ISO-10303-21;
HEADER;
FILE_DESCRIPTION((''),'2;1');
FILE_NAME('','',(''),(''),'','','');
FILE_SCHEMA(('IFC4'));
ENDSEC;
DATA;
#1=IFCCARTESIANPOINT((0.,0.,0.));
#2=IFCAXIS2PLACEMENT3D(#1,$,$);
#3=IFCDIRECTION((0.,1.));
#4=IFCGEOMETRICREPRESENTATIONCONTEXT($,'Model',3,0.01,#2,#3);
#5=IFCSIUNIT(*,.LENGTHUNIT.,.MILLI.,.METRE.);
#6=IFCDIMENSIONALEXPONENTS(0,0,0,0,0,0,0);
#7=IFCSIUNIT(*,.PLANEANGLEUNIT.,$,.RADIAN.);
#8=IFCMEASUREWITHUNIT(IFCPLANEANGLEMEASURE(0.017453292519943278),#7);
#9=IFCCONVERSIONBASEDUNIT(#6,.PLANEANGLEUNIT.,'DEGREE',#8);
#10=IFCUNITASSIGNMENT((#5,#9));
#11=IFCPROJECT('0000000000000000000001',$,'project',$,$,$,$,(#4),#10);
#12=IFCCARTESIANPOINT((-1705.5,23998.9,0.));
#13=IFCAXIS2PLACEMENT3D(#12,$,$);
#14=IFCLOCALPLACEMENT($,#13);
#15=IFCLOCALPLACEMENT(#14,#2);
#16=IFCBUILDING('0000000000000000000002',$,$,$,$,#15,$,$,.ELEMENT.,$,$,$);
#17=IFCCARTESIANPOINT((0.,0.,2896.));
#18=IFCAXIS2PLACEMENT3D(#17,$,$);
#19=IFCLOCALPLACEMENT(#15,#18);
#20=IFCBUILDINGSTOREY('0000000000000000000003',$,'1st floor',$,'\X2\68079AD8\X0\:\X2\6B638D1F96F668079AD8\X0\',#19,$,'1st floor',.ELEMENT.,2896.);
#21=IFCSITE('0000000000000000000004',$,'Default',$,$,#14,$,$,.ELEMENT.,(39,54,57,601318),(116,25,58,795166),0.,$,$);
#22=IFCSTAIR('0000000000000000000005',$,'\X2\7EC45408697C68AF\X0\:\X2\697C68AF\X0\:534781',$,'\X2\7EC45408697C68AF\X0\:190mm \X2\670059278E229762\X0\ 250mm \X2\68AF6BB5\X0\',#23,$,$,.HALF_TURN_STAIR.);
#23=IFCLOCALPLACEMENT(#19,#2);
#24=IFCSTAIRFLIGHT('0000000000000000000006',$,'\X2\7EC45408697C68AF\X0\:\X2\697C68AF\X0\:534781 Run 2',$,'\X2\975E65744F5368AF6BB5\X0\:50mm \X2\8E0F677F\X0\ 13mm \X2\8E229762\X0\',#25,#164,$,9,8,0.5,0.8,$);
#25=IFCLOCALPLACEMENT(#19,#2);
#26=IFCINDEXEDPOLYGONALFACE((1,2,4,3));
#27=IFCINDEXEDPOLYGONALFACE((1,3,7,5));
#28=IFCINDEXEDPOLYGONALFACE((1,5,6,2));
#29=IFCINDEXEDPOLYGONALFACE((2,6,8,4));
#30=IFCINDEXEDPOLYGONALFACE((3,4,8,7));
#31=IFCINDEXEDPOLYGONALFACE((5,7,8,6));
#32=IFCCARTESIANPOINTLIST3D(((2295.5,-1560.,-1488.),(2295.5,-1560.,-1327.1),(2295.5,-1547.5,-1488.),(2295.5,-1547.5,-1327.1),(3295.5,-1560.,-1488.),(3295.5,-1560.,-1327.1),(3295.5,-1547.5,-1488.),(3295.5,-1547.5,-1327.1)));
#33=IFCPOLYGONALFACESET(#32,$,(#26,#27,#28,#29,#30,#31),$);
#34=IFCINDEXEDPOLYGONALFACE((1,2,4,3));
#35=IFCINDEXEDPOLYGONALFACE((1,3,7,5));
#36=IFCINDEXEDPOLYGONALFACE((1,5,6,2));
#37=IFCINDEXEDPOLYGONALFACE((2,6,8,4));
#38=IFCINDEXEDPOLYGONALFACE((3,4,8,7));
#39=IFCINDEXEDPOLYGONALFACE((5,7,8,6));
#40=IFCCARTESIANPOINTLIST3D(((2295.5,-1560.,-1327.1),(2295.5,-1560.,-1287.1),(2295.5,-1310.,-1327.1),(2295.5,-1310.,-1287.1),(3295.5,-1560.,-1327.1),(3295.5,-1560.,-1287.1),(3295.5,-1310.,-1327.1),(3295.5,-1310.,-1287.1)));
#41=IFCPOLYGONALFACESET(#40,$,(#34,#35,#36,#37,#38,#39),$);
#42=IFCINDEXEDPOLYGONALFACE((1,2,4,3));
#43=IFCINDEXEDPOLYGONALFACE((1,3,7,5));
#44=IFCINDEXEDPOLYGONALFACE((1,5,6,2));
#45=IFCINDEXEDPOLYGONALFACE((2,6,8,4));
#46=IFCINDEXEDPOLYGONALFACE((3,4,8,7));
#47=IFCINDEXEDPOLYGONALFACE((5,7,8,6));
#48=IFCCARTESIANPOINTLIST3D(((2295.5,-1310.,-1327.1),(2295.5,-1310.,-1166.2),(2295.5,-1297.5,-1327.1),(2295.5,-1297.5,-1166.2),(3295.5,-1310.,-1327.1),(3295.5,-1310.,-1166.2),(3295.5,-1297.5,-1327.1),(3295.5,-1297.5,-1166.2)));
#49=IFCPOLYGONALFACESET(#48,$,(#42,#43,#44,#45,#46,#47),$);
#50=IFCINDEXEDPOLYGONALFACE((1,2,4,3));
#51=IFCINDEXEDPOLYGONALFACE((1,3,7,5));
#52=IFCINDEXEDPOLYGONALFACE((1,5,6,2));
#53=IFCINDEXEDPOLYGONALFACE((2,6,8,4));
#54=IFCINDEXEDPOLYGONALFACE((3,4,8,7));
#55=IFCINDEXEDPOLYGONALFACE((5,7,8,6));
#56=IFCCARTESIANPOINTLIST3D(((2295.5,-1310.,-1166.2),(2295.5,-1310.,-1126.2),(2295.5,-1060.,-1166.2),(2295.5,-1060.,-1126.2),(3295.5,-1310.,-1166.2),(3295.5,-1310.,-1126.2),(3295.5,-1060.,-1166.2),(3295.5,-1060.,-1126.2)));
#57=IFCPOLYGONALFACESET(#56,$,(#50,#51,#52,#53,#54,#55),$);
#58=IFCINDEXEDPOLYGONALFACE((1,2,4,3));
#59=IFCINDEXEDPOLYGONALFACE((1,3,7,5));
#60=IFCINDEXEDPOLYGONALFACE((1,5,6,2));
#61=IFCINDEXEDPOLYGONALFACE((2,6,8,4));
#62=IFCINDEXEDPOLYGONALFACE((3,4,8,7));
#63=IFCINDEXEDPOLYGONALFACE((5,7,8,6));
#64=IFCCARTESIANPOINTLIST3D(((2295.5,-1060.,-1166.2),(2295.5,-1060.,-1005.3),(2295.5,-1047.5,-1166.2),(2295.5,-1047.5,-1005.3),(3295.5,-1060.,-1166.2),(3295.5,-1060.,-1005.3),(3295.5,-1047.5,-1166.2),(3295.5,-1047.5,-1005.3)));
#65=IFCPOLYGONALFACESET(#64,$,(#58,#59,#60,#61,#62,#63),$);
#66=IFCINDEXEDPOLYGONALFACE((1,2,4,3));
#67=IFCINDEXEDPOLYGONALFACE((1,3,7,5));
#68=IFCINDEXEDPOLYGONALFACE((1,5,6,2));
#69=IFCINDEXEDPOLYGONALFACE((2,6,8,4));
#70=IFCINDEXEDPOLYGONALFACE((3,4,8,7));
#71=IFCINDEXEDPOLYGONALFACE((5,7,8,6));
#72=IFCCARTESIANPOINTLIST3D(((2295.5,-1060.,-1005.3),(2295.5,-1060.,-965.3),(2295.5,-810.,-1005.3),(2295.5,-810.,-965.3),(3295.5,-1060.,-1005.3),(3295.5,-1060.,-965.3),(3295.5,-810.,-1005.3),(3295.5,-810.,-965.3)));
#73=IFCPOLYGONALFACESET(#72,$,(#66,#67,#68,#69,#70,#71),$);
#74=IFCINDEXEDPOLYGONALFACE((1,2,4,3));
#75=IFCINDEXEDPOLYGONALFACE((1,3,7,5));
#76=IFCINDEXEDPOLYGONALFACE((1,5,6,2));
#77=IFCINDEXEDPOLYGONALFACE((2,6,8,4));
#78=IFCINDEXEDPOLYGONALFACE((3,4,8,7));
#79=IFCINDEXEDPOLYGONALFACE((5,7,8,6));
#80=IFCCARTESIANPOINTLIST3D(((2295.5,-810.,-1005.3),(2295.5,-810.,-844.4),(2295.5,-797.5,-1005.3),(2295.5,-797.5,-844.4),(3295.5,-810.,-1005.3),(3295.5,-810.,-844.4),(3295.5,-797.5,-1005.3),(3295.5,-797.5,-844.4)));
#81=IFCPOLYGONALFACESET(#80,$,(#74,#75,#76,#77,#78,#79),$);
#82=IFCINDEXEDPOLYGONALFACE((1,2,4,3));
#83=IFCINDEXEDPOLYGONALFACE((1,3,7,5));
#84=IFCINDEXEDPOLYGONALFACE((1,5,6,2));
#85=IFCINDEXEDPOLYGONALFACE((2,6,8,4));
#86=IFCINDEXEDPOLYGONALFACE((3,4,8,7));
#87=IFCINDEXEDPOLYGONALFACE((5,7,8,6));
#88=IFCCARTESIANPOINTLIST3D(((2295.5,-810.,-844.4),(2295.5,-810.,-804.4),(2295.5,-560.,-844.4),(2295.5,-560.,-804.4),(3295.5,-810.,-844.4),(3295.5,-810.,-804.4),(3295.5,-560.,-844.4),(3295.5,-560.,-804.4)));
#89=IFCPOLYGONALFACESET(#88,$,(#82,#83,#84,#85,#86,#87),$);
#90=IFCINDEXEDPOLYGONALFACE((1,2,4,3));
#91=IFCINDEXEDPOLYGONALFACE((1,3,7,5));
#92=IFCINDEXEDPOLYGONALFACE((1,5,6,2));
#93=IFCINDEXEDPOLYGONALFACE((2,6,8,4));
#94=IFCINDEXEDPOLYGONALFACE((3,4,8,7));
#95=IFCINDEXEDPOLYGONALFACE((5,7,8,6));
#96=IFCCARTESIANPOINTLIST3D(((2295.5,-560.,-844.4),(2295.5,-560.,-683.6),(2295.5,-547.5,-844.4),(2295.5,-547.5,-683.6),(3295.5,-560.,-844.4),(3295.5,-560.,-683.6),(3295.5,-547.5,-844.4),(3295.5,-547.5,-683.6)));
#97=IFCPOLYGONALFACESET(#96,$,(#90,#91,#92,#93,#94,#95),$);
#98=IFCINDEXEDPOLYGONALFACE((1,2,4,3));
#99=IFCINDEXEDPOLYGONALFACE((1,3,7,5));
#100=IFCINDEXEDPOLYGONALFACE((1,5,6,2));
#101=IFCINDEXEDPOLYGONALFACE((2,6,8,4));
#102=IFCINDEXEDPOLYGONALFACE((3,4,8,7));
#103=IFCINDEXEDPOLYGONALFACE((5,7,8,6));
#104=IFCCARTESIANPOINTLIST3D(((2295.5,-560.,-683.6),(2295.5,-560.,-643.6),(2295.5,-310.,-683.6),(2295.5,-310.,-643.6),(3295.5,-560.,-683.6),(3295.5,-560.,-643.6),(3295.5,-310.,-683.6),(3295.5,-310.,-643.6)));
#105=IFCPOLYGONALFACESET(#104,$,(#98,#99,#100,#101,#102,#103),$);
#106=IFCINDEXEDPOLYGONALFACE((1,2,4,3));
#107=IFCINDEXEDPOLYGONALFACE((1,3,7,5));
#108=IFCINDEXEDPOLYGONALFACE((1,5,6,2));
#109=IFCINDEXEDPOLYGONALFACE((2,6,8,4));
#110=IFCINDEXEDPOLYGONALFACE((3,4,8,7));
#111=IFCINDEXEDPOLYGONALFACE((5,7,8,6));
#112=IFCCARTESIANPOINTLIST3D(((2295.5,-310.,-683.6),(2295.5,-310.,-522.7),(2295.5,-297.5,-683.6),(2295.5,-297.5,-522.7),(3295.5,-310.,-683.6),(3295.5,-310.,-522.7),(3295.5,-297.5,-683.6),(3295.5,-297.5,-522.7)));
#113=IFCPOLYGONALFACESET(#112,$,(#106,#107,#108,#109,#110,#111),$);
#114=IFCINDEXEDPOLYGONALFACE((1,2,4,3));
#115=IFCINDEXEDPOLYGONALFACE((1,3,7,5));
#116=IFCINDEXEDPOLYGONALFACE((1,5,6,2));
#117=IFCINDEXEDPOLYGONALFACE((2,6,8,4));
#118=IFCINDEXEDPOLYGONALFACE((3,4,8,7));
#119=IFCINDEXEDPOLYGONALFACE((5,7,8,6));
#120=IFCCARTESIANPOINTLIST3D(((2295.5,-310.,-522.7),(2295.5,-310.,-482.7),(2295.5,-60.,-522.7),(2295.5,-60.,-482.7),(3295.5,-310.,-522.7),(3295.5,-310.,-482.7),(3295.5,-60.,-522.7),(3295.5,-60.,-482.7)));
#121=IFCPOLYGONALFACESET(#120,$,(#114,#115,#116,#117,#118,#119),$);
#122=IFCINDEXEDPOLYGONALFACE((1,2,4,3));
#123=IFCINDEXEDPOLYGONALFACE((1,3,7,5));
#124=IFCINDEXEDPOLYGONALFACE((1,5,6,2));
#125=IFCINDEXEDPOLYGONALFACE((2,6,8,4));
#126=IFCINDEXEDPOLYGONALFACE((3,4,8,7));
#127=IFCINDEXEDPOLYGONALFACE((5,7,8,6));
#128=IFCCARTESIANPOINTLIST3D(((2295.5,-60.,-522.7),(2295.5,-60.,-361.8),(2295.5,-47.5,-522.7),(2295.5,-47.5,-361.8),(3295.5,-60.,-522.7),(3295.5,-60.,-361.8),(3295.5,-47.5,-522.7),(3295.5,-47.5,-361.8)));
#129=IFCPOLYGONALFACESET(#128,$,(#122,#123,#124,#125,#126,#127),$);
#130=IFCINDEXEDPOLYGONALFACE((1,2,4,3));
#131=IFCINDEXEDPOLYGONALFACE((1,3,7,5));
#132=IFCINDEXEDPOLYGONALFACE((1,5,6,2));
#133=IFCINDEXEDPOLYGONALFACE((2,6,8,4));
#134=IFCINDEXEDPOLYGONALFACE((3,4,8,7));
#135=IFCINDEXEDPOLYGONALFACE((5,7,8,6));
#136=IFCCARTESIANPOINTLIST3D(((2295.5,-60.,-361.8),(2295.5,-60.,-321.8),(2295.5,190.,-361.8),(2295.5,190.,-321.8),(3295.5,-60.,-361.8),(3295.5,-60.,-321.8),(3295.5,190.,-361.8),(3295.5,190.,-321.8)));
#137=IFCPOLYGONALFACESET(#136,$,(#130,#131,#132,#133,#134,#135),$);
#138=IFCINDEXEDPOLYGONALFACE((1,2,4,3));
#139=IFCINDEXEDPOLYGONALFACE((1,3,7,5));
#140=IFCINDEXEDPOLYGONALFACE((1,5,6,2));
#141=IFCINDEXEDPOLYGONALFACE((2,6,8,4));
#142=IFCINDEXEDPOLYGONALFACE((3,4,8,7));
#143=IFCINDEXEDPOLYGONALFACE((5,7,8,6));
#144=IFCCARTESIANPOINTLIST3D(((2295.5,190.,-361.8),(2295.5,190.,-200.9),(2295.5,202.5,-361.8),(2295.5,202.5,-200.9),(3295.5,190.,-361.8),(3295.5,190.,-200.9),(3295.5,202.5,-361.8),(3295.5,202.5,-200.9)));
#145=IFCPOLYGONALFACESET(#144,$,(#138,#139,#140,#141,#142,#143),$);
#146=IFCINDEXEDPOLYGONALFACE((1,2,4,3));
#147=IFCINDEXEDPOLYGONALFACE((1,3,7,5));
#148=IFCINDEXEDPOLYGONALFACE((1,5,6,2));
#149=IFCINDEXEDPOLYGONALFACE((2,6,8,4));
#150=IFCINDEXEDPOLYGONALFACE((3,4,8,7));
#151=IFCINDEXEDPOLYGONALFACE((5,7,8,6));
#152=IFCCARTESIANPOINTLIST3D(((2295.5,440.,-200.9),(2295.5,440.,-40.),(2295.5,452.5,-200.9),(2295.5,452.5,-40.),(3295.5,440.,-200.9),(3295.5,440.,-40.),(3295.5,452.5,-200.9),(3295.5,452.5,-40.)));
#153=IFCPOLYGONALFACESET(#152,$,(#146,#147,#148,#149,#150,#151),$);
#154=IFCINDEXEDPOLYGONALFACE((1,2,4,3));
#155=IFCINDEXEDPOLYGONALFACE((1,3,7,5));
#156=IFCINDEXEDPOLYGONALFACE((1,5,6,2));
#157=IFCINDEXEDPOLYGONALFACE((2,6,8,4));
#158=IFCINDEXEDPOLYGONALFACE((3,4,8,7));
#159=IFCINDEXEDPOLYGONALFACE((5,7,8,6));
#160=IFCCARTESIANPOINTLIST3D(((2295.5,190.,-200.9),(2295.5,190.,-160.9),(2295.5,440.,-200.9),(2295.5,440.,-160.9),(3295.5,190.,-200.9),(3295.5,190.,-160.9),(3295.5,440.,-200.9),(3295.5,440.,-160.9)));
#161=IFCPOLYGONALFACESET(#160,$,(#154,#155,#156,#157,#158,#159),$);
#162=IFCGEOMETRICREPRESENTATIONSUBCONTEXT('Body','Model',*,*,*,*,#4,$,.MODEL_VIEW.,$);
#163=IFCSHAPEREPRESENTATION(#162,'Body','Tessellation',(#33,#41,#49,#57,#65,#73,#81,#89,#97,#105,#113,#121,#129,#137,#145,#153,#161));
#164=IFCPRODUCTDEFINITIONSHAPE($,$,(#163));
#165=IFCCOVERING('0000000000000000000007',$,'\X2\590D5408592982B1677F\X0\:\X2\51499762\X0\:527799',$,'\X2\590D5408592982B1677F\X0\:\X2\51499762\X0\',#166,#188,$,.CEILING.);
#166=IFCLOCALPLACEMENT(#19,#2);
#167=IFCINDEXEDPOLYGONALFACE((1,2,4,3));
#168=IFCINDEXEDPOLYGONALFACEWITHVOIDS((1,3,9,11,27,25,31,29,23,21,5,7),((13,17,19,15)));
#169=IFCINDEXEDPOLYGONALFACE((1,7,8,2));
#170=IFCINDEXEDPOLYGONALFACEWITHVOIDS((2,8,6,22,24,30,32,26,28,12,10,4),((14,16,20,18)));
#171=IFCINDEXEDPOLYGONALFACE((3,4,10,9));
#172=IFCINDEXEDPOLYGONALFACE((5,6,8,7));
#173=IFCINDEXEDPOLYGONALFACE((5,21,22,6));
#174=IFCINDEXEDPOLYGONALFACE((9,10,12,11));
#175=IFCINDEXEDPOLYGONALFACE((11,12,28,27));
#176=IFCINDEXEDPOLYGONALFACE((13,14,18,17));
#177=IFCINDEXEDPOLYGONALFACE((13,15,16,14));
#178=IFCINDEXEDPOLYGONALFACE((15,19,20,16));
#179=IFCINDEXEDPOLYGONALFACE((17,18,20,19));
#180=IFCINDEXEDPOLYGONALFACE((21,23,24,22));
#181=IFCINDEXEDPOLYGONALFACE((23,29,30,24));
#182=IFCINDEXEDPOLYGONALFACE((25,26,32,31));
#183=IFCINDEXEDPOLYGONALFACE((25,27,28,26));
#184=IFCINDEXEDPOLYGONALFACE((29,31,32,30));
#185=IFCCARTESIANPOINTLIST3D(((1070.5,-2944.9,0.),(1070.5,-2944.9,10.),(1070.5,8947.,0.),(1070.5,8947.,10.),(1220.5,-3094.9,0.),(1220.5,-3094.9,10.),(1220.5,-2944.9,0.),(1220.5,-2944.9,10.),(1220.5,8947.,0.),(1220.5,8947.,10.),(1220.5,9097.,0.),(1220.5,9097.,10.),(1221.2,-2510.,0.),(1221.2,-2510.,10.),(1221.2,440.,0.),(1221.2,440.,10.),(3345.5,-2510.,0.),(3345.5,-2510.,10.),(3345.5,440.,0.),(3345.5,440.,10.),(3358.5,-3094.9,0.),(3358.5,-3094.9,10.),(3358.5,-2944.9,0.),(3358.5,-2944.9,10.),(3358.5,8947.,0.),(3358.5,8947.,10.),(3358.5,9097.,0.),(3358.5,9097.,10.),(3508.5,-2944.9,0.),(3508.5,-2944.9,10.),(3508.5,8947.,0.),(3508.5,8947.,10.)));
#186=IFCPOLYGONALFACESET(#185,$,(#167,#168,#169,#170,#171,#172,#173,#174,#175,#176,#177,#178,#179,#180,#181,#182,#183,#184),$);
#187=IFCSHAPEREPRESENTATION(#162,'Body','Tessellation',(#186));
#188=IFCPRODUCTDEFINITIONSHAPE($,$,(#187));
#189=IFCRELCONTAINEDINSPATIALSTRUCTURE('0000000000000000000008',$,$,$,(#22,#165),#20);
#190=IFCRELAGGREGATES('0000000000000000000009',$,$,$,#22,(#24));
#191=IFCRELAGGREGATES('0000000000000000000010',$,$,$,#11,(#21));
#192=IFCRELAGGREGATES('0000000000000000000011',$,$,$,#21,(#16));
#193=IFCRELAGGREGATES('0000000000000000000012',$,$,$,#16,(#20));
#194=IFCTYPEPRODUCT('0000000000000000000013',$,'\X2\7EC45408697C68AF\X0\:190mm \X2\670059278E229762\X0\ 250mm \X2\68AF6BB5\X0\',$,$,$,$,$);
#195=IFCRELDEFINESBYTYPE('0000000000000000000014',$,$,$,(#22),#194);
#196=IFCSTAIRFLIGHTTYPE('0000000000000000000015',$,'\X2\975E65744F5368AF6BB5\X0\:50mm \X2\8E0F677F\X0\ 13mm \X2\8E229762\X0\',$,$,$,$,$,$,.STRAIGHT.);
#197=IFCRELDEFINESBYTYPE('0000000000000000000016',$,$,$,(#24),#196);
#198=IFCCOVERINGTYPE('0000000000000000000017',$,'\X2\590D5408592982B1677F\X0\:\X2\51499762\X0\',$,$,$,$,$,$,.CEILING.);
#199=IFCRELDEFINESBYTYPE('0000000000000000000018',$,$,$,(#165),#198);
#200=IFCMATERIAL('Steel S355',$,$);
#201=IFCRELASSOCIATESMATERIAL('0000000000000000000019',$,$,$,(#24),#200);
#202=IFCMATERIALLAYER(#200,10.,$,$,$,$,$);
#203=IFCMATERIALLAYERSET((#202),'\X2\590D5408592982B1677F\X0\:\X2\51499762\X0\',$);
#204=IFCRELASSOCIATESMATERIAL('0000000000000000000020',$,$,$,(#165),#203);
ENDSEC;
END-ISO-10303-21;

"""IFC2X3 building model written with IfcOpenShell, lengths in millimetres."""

from ifc_helpers import new_model, entity, si_unit, converted_unit, direction, frame, frame_2d, origin, origin_2d_with_axis, place, context, subcontext, project, spatial, polyline, rectangle, outline, extrude, material, layer, layer_set, layer_usage, type_object, element, aggregate, save


model = new_model("IFC2X3")

# Units and contexts
model_context = context("Model", 3, precision=0.01, world=origin(), true_north=direction((0.0, 1.0)))
body_context = subcontext(model_context, "Body", "Model", "MODEL_VIEW")
ifc_project = project(units=[si_unit("LENGTHUNIT", "METRE", prefix="MILLI"), converted_unit("PLANEANGLEUNIT", "DEGREE", entity("IfcPlaneAngleMeasure", 0.017453292519943278), si_unit("PLANEANGLEUNIT", "RADIAN"), dimensions=[0, 0, 0, 0, 0, 0, 0])], contexts=[model_context])

# Site, building, storey
site_placement = place(None, frame((-1705.5, 23998.9, 0.0)))
site = spatial("IfcSite", under=ifc_project, at=site_placement, Name="Default", CompositionType="ELEMENT", RefLatitude=(39, 54, 57, 601318), RefLongitude=(116, 25, 58, 795166), RefElevation=0.0)
building_placement = place(site_placement, origin())
building = spatial("IfcBuilding", under=site, at=building_placement, CompositionType="ELEMENT")
storey_placement = place(building_placement, frame((0.0, 0.0, 2896.0)))
storey = spatial("IfcBuildingStorey", under=building, at=storey_placement, Name="1st floor", ObjectType="标高:正负零标高", LongName="1st floor", CompositionType="ELEMENT", Elevation=2896.0)

# Shared definitions
ifc_material_1 = material(Name="Steel S355")

# Stair
type_product = type_object("IfcTypeProduct", Name="组合楼梯:190mm 最大踢面 250mm 梯段")
stair_placement = place(storey_placement, origin())
stair = element("IfcStair", 1, at=stair_placement, inside=storey, type_object=type_product, Name="组合楼梯:楼梯:534781", ObjectType="组合楼梯:190mm 最大踢面 250mm 梯段", ShapeType="HALF_TURN_STAIR")

# Stair flight
stair_flight_type = type_object("IfcStairFlightType", Name="非整体梯段:50mm 踏板 13mm 踢面", PredefinedType="STRAIGHT")
stair_flight_1_placement = place(stair_placement, origin())
stair_flight_1 = element("IfcStairFlight", 2, at=stair_flight_1_placement, type_object=stair_flight_type, material=ifc_material_1, Name="组合楼梯:楼梯:534781 Run 2", ObjectType="非整体梯段:50mm 踏板 13mm 踢面", NumberOfRiser=9, NumberOfTreads=8, RiserHeight=0.5, TreadLength=0.8, context=body_context, shape_type="SweptSolid", body=[
    extrude(rectangle(XDim=1000.0, YDim=12.5, at=origin_2d_with_axis()), frame((2795.5, -1553.8, -1488.0), z_axis=(0.0, 0.0, 1.0), x_axis=(-1.0, 0.0, 0.0)), (0.0, 0.0, 1.0), 160.9),
    extrude(rectangle(XDim=250.0, YDim=1000.0, at=frame_2d((0.0, 0.0), x_axis=(1.0, 0.0))), frame((2795.5, -1435.0, -1327.1), z_axis=(0.0, 0.0, 1.0), x_axis=(0.0, -1.0, 0.0)), (0.0, 0.0, 1.0), 40.0),
    extrude(rectangle(XDim=1000.0, YDim=12.5, at=origin_2d_with_axis()), frame((2795.5, -1303.8, -1327.1), z_axis=(0.0, 0.0, 1.0), x_axis=(-1.0, 0.0, 0.0)), (0.0, 0.0, 1.0), 160.9),
    extrude(rectangle(XDim=250.0, YDim=1000.0, at=frame_2d((0.0, 0.0), x_axis=(1.0, 0.0))), frame((2795.5, -1185.0, -1166.2), z_axis=(0.0, 0.0, 1.0), x_axis=(0.0, -1.0, 0.0)), (0.0, 0.0, 1.0), 40.0),
    extrude(rectangle(XDim=1000.0, YDim=12.5, at=origin_2d_with_axis()), frame((2795.5, -1053.8, -1166.2), z_axis=(0.0, 0.0, 1.0), x_axis=(-1.0, 0.0, 0.0)), (0.0, 0.0, 1.0), 160.9),
    extrude(rectangle(XDim=250.0, YDim=1000.0, at=frame_2d((0.0, 0.0), x_axis=(1.0, 0.0))), frame((2795.5, -935.0, -1005.3), z_axis=(0.0, 0.0, 1.0), x_axis=(0.0, -1.0, 0.0)), (0.0, 0.0, 1.0), 40.0),
    extrude(rectangle(XDim=1000.0, YDim=12.5, at=origin_2d_with_axis()), frame((2795.5, -803.8, -1005.3), z_axis=(0.0, 0.0, 1.0), x_axis=(-1.0, 0.0, 0.0)), (0.0, 0.0, 1.0), 160.9),
    extrude(rectangle(XDim=250.0, YDim=1000.0, at=frame_2d((0.0, 0.0), x_axis=(1.0, 0.0))), frame((2795.5, -685.0, -844.4), z_axis=(0.0, 0.0, 1.0), x_axis=(0.0, -1.0, 0.0)), (0.0, 0.0, 1.0), 40.0),
    extrude(rectangle(XDim=1000.0, YDim=12.5, at=origin_2d_with_axis()), frame((2795.5, -553.8, -844.4), z_axis=(0.0, 0.0, 1.0), x_axis=(-1.0, 0.0, 0.0)), (0.0, 0.0, 1.0), 160.9),
    extrude(rectangle(XDim=250.0, YDim=1000.0, at=frame_2d((0.0, 0.0), x_axis=(1.0, 0.0))), frame((2795.5, -435.0, -683.6), z_axis=(0.0, 0.0, 1.0), x_axis=(0.0, -1.0, 0.0)), (0.0, 0.0, 1.0), 40.0),
    extrude(rectangle(XDim=1000.0, YDim=12.5, at=frame_2d((0.0, 0.0), x_axis=(1.0, 0.0))), frame((2795.5, -303.8, -683.6), z_axis=(0.0, 0.0, 1.0), x_axis=(-1.0, 0.0, 0.0)), (0.0, 0.0, 1.0), 160.9),
    extrude(rectangle(XDim=250.0, YDim=1000.0, at=frame_2d((0.0, 0.0), x_axis=(1.0, 0.0))), frame((2795.5, -185.0, -522.7), z_axis=(0.0, 0.0, 1.0), x_axis=(0.0, -1.0, 0.0)), (0.0, 0.0, 1.0), 40.0),
    extrude(rectangle(XDim=1000.0, YDim=12.5, at=frame_2d((0.0, 0.0), x_axis=(1.0, 0.0))), frame((2795.5, -53.8, -522.7), z_axis=(0.0, 0.0, 1.0), x_axis=(-1.0, 0.0, 0.0)), (0.0, 0.0, 1.0), 160.9),
    extrude(rectangle(XDim=250.0, YDim=1000.0, at=frame_2d((0.0, 0.0), x_axis=(1.0, 0.0))), frame((2795.5, 65.0, -361.8), z_axis=(0.0, 0.0, 1.0), x_axis=(0.0, -1.0, 0.0)), (0.0, 0.0, 1.0), 40.0),
    extrude(rectangle(XDim=1000.0, YDim=12.5, at=frame_2d((0.0, 0.0), x_axis=(1.0, 0.0))), frame((2795.5, 196.2, -361.8), z_axis=(0.0, 0.0, 1.0), x_axis=(-1.0, 0.0, 0.0)), (0.0, 0.0, 1.0), 160.9),
    extrude(rectangle(XDim=1000.0, YDim=12.5, at=origin_2d_with_axis()), frame((2795.5, 446.2, -200.9), z_axis=(0.0, 0.0, 1.0), x_axis=(-1.0, 0.0, 0.0)), (0.0, 0.0, 1.0), 160.9),
    extrude(rectangle(XDim=250.0, YDim=1000.0, at=frame_2d((0.0, 0.0), x_axis=(1.0, 0.0))), frame((2795.5, 315.0, -200.9), z_axis=(0.0, 0.0, 1.0), x_axis=(0.0, -1.0, 0.0)), (0.0, 0.0, 1.0), 40.0),
])
aggregate(stair, [stair_flight_1])

# Covering
ifc_layer_1 = layer(ifc_material_1, 10.0)
ifc_layer_set_1 = layer_set([ifc_layer_1], Name="复合天花板:光面")
ifc_layer_usage_1 = layer_usage(ifc_layer_set_1, "AXIS3", "NEGATIVE", 10.0)
covering_type = type_object("IfcCoveringType", Name="复合天花板:光面", PredefinedType="CEILING")
covering_placement = place(storey_placement, origin())
element("IfcCovering", 3, at=covering_placement, inside=storey, type_object=covering_type, material=ifc_layer_usage_1, Name="复合天花板:光面:527799", ObjectType="复合天花板:光面", PredefinedType="CEILING", context=body_context, shape_type="SweptSolid", body=[
    extrude(outline(polyline([(5946.0, -1069.0), (6096.0, -1069.0), (6096.0, 1069.0), (5945.9, 1069.0), (5945.9, 1219.0), (-5946.0, 1219.0), (-5946.0, 1069.0), (-6096.0, 1069.0), (-6096.0, -1069.0), (-5946.0, -1069.0), (-5946.0, -1219.0), (5946.0, -1219.0), (5946.0, -1069.0)]), holes=[polyline([(-2561.0, 1068.3), (-2561.0, -1056.0), (-5511.0, -1056.0), (-5511.0, 1068.3), (-2561.0, 1068.3)])]), frame((2289.5, 3001.0, 0.0), z_axis=(0.0, 0.0, 1.0), x_axis=(0.0, 1.0, 0.0)), (0.0, 0.0, 1.0), 10.0),
])

save(model, "model.ifc")
